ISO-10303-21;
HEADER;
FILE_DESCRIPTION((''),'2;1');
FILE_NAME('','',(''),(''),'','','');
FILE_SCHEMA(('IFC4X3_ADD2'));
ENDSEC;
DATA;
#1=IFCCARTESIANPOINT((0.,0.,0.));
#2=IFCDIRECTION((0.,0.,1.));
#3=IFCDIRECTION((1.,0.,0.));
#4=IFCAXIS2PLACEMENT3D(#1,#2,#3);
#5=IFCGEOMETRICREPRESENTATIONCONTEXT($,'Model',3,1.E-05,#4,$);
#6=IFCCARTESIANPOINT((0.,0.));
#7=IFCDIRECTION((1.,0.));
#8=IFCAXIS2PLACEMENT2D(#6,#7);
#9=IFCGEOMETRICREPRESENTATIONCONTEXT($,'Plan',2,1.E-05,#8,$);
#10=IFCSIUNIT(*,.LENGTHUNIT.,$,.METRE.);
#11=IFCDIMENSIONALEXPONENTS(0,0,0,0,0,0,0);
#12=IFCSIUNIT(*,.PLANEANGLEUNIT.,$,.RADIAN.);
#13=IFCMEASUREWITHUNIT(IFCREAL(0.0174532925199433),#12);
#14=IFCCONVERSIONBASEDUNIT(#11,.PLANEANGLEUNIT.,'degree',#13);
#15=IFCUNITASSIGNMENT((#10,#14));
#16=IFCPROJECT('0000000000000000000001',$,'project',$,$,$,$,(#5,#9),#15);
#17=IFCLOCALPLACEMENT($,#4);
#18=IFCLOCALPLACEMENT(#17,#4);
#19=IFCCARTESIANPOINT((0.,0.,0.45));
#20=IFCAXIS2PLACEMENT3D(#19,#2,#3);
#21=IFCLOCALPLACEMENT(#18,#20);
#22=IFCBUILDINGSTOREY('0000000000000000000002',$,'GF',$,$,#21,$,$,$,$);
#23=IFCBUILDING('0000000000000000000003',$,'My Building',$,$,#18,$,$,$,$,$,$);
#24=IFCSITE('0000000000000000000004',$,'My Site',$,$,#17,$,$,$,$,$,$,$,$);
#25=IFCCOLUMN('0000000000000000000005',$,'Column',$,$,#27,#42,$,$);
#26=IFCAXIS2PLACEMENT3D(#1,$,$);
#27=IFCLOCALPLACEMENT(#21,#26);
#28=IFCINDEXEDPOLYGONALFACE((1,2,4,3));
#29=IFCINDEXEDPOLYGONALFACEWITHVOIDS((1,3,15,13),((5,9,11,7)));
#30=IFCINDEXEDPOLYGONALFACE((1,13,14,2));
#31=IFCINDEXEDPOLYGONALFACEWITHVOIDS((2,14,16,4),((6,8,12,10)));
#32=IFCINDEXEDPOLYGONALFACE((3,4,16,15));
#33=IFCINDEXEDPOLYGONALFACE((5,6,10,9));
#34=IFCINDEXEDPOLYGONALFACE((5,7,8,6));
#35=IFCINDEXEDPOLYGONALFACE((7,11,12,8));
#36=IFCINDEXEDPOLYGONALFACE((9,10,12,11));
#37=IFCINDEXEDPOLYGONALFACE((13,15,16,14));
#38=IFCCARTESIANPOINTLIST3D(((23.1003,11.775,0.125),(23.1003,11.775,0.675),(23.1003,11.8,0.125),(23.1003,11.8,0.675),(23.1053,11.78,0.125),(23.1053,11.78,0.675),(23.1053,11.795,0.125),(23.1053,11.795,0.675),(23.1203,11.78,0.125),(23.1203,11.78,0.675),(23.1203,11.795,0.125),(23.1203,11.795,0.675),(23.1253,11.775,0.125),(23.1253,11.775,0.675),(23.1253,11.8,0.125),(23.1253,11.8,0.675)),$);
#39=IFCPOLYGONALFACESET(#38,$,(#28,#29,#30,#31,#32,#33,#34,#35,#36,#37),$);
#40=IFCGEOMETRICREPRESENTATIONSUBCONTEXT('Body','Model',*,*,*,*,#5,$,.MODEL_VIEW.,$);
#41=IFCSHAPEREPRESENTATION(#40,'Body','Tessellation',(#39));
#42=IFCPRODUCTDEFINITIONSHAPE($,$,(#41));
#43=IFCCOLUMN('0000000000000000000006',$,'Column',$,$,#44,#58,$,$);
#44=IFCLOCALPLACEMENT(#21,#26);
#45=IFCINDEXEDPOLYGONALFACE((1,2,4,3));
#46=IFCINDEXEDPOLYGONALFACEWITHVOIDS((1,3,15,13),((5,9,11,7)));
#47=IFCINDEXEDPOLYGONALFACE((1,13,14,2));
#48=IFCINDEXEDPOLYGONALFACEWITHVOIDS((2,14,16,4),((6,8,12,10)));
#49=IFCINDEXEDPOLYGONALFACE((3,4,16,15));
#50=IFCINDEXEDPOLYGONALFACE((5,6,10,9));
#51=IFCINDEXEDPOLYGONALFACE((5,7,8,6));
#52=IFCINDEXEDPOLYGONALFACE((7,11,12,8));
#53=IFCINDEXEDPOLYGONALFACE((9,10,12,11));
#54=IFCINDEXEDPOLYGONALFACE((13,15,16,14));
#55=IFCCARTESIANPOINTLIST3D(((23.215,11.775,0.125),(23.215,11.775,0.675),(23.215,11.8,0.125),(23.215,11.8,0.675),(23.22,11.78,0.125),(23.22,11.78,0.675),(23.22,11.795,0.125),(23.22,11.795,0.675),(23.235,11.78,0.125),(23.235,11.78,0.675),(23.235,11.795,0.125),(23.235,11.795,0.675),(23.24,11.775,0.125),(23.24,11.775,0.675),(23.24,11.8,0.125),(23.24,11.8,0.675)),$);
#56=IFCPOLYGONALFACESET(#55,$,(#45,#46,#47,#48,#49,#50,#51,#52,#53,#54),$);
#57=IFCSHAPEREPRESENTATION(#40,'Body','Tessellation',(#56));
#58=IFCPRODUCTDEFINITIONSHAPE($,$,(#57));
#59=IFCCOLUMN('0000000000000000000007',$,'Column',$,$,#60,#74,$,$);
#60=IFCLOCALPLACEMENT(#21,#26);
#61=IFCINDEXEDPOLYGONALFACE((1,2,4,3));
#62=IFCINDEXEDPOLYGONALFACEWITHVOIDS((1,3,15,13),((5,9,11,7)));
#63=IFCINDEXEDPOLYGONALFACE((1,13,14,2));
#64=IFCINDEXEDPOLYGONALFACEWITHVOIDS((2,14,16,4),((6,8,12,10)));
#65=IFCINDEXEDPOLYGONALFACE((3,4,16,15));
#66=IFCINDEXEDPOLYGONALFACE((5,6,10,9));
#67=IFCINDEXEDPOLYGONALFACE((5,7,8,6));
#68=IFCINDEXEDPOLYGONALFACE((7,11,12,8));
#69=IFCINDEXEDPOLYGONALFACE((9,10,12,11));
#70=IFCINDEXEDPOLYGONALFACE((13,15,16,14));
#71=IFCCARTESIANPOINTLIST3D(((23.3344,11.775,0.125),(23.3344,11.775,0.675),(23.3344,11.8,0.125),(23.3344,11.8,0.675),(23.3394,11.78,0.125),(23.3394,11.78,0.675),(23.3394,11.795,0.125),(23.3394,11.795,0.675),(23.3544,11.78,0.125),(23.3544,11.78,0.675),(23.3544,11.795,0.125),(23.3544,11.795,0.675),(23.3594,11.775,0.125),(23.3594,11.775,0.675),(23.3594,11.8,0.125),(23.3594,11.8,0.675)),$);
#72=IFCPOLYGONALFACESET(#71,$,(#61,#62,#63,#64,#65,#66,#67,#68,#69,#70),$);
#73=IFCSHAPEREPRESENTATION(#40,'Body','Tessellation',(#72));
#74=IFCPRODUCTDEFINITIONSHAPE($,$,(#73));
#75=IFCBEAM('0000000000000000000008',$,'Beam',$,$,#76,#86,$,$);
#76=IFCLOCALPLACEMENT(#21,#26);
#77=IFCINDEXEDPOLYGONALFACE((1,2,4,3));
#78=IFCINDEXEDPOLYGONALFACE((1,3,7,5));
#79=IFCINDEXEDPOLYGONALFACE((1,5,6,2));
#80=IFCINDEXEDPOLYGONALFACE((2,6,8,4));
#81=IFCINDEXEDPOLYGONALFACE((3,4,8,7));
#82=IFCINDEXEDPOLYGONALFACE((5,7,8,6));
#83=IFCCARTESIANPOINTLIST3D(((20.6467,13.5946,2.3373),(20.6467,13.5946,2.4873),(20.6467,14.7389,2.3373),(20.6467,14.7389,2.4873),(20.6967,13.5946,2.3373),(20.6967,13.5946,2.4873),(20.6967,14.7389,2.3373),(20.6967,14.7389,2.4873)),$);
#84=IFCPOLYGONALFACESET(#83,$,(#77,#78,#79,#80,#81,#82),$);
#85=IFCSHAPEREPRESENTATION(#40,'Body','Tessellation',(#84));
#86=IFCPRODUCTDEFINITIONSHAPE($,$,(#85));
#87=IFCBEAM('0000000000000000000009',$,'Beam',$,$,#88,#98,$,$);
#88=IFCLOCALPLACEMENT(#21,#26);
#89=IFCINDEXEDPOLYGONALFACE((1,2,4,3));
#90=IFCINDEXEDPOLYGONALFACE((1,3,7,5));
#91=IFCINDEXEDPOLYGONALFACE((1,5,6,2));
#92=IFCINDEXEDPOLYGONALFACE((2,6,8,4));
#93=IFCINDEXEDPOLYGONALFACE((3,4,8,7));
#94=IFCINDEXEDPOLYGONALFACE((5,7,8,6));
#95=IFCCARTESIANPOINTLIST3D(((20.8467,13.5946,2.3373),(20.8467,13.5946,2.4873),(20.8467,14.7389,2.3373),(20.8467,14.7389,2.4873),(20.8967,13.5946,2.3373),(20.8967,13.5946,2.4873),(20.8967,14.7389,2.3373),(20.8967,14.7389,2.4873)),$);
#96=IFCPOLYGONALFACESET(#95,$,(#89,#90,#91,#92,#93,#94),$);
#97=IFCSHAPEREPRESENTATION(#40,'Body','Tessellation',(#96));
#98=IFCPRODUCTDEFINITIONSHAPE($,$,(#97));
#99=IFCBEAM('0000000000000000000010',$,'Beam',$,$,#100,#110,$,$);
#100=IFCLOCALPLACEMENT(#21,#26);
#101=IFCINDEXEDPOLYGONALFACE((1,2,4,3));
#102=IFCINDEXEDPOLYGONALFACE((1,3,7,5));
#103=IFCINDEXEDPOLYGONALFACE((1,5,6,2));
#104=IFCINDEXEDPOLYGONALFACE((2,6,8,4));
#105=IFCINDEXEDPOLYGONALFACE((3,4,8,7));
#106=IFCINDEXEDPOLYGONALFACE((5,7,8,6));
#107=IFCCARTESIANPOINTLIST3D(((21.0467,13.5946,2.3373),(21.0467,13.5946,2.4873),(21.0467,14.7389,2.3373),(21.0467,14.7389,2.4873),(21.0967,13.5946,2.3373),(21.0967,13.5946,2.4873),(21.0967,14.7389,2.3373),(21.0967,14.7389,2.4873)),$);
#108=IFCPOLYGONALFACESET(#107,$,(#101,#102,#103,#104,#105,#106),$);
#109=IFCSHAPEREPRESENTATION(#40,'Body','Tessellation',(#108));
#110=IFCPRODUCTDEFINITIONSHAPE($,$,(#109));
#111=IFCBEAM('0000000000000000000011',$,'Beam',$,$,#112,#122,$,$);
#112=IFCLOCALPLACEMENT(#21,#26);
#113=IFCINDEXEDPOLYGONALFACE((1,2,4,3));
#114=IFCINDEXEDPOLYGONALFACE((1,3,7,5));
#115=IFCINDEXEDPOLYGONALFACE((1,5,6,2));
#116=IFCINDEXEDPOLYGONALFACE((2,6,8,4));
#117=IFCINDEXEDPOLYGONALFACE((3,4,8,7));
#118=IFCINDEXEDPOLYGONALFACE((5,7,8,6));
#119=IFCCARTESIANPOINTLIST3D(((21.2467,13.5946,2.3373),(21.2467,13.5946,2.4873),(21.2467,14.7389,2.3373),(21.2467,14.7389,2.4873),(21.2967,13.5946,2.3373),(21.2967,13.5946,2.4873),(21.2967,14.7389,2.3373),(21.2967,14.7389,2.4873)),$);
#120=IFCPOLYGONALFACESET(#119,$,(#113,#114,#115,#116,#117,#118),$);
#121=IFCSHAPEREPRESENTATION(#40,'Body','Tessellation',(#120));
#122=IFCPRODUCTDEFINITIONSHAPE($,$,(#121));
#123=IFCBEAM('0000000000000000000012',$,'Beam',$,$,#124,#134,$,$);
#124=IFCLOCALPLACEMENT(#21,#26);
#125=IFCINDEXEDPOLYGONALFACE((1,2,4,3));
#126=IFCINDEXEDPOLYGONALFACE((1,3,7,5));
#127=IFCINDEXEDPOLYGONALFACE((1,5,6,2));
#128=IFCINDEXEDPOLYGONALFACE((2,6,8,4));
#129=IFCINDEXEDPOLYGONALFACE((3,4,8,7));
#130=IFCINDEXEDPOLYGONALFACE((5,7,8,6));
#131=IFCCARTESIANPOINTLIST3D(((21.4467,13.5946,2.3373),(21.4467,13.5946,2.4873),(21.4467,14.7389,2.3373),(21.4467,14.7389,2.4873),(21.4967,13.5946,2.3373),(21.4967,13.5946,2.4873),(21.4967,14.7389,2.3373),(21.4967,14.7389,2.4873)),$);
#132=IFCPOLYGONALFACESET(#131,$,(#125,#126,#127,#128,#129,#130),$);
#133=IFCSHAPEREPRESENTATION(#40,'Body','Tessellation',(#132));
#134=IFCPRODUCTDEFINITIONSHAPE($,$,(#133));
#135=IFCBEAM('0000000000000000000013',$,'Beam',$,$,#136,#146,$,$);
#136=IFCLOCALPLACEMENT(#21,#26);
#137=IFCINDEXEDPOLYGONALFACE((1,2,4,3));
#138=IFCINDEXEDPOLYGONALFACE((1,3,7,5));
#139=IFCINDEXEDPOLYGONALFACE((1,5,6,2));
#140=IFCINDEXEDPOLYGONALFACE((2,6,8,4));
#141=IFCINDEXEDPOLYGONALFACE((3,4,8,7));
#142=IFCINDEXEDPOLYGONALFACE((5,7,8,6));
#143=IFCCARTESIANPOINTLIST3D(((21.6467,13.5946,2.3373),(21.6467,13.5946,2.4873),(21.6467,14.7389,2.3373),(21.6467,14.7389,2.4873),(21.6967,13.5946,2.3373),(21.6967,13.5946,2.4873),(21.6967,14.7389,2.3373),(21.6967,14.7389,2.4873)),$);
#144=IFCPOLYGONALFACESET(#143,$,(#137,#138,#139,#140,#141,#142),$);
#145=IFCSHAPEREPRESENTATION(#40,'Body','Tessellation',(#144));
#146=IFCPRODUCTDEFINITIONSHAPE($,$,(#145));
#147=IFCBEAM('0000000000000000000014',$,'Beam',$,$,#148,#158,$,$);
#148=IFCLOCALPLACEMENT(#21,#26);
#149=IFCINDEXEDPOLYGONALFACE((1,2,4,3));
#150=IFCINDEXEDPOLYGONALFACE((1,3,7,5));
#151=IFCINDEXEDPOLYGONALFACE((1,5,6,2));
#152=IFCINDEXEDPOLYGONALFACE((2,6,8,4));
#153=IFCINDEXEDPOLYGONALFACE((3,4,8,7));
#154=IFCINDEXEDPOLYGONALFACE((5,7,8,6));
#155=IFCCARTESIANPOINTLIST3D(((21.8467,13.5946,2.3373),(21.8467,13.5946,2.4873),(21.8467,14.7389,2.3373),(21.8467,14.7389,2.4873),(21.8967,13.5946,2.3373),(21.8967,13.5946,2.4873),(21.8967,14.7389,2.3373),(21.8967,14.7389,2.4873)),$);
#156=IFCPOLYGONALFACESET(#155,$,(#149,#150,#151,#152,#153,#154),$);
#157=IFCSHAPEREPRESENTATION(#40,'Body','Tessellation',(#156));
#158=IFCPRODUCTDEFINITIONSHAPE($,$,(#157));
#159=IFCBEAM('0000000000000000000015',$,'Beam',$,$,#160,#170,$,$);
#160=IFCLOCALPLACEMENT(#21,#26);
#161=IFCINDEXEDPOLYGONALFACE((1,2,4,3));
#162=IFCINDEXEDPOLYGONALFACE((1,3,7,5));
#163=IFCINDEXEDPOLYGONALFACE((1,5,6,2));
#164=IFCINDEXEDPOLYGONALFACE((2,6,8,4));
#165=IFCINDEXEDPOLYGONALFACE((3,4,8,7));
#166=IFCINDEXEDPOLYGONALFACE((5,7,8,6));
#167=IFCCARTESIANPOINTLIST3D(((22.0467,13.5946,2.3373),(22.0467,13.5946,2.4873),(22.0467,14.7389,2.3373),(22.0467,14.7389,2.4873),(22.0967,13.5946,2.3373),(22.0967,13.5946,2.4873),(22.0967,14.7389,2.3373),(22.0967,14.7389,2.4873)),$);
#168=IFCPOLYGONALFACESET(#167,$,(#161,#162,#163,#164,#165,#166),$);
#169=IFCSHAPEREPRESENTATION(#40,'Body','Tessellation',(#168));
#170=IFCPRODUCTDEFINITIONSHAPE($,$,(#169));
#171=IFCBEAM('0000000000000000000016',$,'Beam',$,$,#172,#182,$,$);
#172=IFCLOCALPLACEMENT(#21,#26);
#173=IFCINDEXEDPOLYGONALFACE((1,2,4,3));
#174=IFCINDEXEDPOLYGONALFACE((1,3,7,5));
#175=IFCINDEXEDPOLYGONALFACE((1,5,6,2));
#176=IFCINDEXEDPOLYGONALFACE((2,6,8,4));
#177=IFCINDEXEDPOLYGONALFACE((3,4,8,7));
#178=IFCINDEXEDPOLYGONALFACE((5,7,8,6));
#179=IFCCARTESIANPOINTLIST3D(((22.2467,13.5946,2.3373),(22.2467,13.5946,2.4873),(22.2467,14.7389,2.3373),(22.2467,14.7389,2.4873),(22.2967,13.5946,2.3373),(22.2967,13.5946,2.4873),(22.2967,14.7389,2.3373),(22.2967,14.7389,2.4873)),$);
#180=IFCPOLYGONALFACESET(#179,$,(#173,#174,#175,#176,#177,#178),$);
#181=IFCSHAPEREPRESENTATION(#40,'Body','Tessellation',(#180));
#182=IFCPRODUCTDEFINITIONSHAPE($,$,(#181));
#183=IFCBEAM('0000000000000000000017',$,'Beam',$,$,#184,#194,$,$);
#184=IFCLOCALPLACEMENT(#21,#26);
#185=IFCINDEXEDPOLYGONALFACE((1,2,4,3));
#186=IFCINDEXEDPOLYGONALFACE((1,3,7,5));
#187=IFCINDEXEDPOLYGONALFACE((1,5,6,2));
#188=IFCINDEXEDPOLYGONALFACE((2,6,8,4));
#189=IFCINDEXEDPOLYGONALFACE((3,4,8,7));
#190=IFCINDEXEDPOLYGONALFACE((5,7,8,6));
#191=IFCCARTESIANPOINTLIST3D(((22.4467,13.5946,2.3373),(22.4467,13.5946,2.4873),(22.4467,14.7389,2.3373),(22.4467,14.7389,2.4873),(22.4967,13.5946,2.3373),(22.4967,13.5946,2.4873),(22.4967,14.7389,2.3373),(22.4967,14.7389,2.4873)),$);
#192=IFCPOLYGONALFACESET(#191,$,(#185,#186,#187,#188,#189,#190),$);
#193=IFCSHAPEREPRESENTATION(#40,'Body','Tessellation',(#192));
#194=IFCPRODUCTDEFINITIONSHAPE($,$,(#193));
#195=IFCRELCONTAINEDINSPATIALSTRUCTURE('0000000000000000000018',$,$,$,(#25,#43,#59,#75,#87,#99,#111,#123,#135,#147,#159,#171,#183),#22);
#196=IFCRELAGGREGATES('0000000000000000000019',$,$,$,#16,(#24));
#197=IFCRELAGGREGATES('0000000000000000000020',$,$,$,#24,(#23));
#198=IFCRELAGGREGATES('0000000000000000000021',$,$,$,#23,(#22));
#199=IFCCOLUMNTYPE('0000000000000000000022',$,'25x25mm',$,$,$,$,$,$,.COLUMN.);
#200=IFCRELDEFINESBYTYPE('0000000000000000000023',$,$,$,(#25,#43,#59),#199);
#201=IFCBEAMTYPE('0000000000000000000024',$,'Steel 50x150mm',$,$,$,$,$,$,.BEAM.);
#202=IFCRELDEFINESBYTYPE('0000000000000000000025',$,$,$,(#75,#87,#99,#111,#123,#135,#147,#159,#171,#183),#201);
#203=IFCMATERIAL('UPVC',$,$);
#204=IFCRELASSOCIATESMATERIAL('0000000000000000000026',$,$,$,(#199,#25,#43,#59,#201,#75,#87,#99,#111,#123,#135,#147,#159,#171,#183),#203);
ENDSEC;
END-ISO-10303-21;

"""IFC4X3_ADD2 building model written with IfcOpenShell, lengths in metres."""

from ifc_helpers import new_model, entity, si_unit, converted_unit, frame, origin_with_axes, origin_2d_with_axis, place, context, subcontext, project, spatial, rectangle, hollow_rectangle, extrude, material, material_profile, profile_set, profile_usage, type_object, element, save


model = new_model("IFC4X3_ADD2")

# Units and contexts
model_context = context("Model", 3, precision=1e-05, world=origin_with_axes())
plan_context = context("Plan", 2, precision=1e-05, world=origin_2d_with_axis())
body_context_1 = subcontext(model_context, "Body", "Model", "MODEL_VIEW")
ifc_project = project(units=[si_unit("LENGTHUNIT", "METRE"), converted_unit("PLANEANGLEUNIT", "degree", entity("IfcReal", 0.0174532925199433), si_unit("PLANEANGLEUNIT", "RADIAN"), dimensions=[0, 0, 0, 0, 0, 0, 0])], contexts=[model_context, plan_context])

# Site, building, storey
site_placement = place(None, origin_with_axes())
site = spatial("IfcSite", under=ifc_project, at=site_placement, Name="My Site")
building_placement = place(site_placement, origin_with_axes())
building = spatial("IfcBuilding", under=site, at=building_placement, Name="My Building")
storey_placement = place(building_placement, frame((0.0, 0.0, 0.45), z_axis=(0.0, 0.0, 1.0), x_axis=(1.0, 0.0, 0.0)))
storey = spatial("IfcBuildingStorey", under=building, at=storey_placement, Name="GF")

# Columns
ifc_material_1 = material(Name="UPVC")
ifc_material_profile_1 = material_profile(ifc_material_1, hollow_rectangle(XDim=0.025, YDim=0.025, WallThickness=0.005))
ifc_profile_set_1 = profile_set([ifc_material_profile_1])
column_type_1 = type_object("IfcColumnType", Name="25x25mm", PredefinedType="COLUMN", material=ifc_profile_set_1)
ifc_profile_usage_1 = profile_usage(ifc_profile_set_1, cardinal=5)
column_1_placement = place(storey_placement, frame((23.1128, 11.7875, 0.125), z_axis=(0.0, 0.0, 1.0), x_axis=(1.0, 0.0, 0.0)))
element("IfcColumn", 1, at=column_1_placement, inside=storey, type_object=column_type_1, material=ifc_profile_usage_1, Name="Column", context=body_context_1, shape_type="SweptSolid", body=[
    extrude(hollow_rectangle(XDim=0.025, YDim=0.025, WallThickness=0.005), origin_with_axes(), (0.0, 0.0, 1.0), 0.55),
])
ifc_profile_usage_2 = profile_usage(ifc_profile_set_1, cardinal=5)
column_2_placement = place(storey_placement, frame((23.2275, 11.7875, 0.125), z_axis=(0.0, 0.0, 1.0), x_axis=(1.0, 0.0, 0.0)))
element("IfcColumn", 2, at=column_2_placement, inside=storey, type_object=column_type_1, material=ifc_profile_usage_2, Name="Column", context=body_context_1, shape_type="SweptSolid", body=[
    extrude(hollow_rectangle(XDim=0.025, YDim=0.025, WallThickness=0.005), origin_with_axes(), (0.0, 0.0, 1.0), 0.55),
])
ifc_profile_usage_3 = profile_usage(ifc_profile_set_1, cardinal=5)
column_3_placement = place(storey_placement, frame((23.3469, 11.7875, 0.125), z_axis=(0.0, 0.0, 1.0), x_axis=(1.0, 0.0, 0.0)))
element("IfcColumn", 3, at=column_3_placement, inside=storey, type_object=column_type_1, material=ifc_profile_usage_3, Name="Column", context=body_context_1, shape_type="SweptSolid", body=[
    extrude(hollow_rectangle(XDim=0.025, YDim=0.025, WallThickness=0.005), origin_with_axes(), (0.0, 0.0, 1.0), 0.55),
])

# Beams
ifc_material_profile_2 = material_profile(ifc_material_1, rectangle(XDim=0.05, YDim=0.15))
ifc_profile_set_2 = profile_set([ifc_material_profile_2])
ifc_profile_usage_4 = profile_usage(ifc_profile_set_2)
beam_type_1 = type_object("IfcBeamType", Name="Steel 50x150mm", PredefinedType="BEAM", material=ifc_profile_set_2)
beam_1_placement = place(storey_placement, frame((20.6717, 14.7389, 2.4123), z_axis=(0.0, -1.0, 0.0), x_axis=(1.0, 0.0, 0.0)))
element("IfcBeam", 4, at=beam_1_placement, inside=storey, type_object=beam_type_1, material=ifc_profile_usage_4, Name="Beam", context=body_context_1, shape_type="SweptSolid", body=[
    extrude(rectangle(XDim=0.05, YDim=0.15), origin_with_axes(), (0.0, 0.0, 1.0), 1.1444),
])
ifc_profile_usage_5 = profile_usage(ifc_profile_set_2)
beam_2_placement = place(storey_placement, frame((20.8717, 14.7389, 2.4123), z_axis=(0.0, -1.0, 0.0), x_axis=(1.0, 0.0, 0.0)))
element("IfcBeam", 5, at=beam_2_placement, inside=storey, type_object=beam_type_1, material=ifc_profile_usage_5, Name="Beam", context=body_context_1, shape_type="SweptSolid", body=[
    extrude(rectangle(XDim=0.05, YDim=0.15), origin_with_axes(), (0.0, 0.0, 1.0), 1.1444),
])
ifc_profile_usage_6 = profile_usage(ifc_profile_set_2)
beam_3_placement = place(storey_placement, frame((21.0717, 14.7389, 2.4123), z_axis=(0.0, -1.0, 0.0), x_axis=(1.0, 0.0, 0.0)))
element("IfcBeam", 6, at=beam_3_placement, inside=storey, type_object=beam_type_1, material=ifc_profile_usage_6, Name="Beam", context=body_context_1, shape_type="SweptSolid", body=[
    extrude(rectangle(XDim=0.05, YDim=0.15), origin_with_axes(), (0.0, 0.0, 1.0), 1.1444),
])
ifc_profile_usage_7 = profile_usage(ifc_profile_set_2)
beam_4_placement = place(storey_placement, frame((21.2717, 14.7389, 2.4123), z_axis=(0.0, -1.0, 0.0), x_axis=(1.0, 0.0, 0.0)))
element("IfcBeam", 7, at=beam_4_placement, inside=storey, type_object=beam_type_1, material=ifc_profile_usage_7, Name="Beam", context=body_context_1, shape_type="SweptSolid", body=[
    extrude(rectangle(XDim=0.05, YDim=0.15), origin_with_axes(), (0.0, 0.0, 1.0), 1.1444),
])
ifc_profile_usage_8 = profile_usage(ifc_profile_set_2)
beam_5_placement = place(storey_placement, frame((21.4717, 14.7389, 2.4123), z_axis=(0.0, -1.0, 0.0), x_axis=(1.0, 0.0, 0.0)))
element("IfcBeam", 8, at=beam_5_placement, inside=storey, type_object=beam_type_1, material=ifc_profile_usage_8, Name="Beam", context=body_context_1, shape_type="SweptSolid", body=[
    extrude(rectangle(XDim=0.05, YDim=0.15), origin_with_axes(), (0.0, 0.0, 1.0), 1.1444),
])
ifc_profile_usage_9 = profile_usage(ifc_profile_set_2)
beam_6_placement = place(storey_placement, frame((21.6717, 14.7389, 2.4123), z_axis=(0.0, -1.0, 0.0), x_axis=(1.0, 0.0, 0.0)))
element("IfcBeam", 9, at=beam_6_placement, inside=storey, type_object=beam_type_1, material=ifc_profile_usage_9, Name="Beam", context=body_context_1, shape_type="SweptSolid", body=[
    extrude(rectangle(XDim=0.05, YDim=0.15), origin_with_axes(), (0.0, 0.0, 1.0), 1.1444),
])
ifc_profile_usage_10 = profile_usage(ifc_profile_set_2)
beam_7_placement = place(storey_placement, frame((21.8717, 14.7389, 2.4123), z_axis=(0.0, -1.0, 0.0), x_axis=(1.0, 0.0, 0.0)))
element("IfcBeam", 10, at=beam_7_placement, inside=storey, type_object=beam_type_1, material=ifc_profile_usage_10, Name="Beam", context=body_context_1, shape_type="SweptSolid", body=[
    extrude(rectangle(XDim=0.05, YDim=0.15), origin_with_axes(), (0.0, 0.0, 1.0), 1.1444),
])
ifc_profile_usage_11 = profile_usage(ifc_profile_set_2)
beam_8_placement = place(storey_placement, frame((22.0717, 14.7389, 2.4123), z_axis=(0.0, -1.0, 0.0), x_axis=(1.0, 0.0, 0.0)))
element("IfcBeam", 11, at=beam_8_placement, inside=storey, type_object=beam_type_1, material=ifc_profile_usage_11, Name="Beam", context=body_context_1, shape_type="SweptSolid", body=[
    extrude(rectangle(XDim=0.05, YDim=0.15), origin_with_axes(), (0.0, 0.0, 1.0), 1.1444),
])
ifc_profile_usage_12 = profile_usage(ifc_profile_set_2)
beam_9_placement = place(storey_placement, frame((22.2717, 14.7389, 2.4123), z_axis=(0.0, -1.0, 0.0), x_axis=(1.0, 0.0, 0.0)))
element("IfcBeam", 12, at=beam_9_placement, inside=storey, type_object=beam_type_1, material=ifc_profile_usage_12, Name="Beam", context=body_context_1, shape_type="SweptSolid", body=[
    extrude(rectangle(XDim=0.05, YDim=0.15), origin_with_axes(), (0.0, 0.0, 1.0), 1.1444),
])
ifc_profile_usage_13 = profile_usage(ifc_profile_set_2)
beam_10_placement = place(storey_placement, frame((22.4717, 14.7389, 2.4123), z_axis=(0.0, -1.0, 0.0), x_axis=(1.0, 0.0, 0.0)))
element("IfcBeam", 13, at=beam_10_placement, inside=storey, type_object=beam_type_1, material=ifc_profile_usage_13, Name="Beam", context=body_context_1, shape_type="SweptSolid", body=[
    extrude(rectangle(XDim=0.05, YDim=0.15), origin_with_axes(), (0.0, 0.0, 1.0), 1.1444),
])

save(model, "model.ifc")
